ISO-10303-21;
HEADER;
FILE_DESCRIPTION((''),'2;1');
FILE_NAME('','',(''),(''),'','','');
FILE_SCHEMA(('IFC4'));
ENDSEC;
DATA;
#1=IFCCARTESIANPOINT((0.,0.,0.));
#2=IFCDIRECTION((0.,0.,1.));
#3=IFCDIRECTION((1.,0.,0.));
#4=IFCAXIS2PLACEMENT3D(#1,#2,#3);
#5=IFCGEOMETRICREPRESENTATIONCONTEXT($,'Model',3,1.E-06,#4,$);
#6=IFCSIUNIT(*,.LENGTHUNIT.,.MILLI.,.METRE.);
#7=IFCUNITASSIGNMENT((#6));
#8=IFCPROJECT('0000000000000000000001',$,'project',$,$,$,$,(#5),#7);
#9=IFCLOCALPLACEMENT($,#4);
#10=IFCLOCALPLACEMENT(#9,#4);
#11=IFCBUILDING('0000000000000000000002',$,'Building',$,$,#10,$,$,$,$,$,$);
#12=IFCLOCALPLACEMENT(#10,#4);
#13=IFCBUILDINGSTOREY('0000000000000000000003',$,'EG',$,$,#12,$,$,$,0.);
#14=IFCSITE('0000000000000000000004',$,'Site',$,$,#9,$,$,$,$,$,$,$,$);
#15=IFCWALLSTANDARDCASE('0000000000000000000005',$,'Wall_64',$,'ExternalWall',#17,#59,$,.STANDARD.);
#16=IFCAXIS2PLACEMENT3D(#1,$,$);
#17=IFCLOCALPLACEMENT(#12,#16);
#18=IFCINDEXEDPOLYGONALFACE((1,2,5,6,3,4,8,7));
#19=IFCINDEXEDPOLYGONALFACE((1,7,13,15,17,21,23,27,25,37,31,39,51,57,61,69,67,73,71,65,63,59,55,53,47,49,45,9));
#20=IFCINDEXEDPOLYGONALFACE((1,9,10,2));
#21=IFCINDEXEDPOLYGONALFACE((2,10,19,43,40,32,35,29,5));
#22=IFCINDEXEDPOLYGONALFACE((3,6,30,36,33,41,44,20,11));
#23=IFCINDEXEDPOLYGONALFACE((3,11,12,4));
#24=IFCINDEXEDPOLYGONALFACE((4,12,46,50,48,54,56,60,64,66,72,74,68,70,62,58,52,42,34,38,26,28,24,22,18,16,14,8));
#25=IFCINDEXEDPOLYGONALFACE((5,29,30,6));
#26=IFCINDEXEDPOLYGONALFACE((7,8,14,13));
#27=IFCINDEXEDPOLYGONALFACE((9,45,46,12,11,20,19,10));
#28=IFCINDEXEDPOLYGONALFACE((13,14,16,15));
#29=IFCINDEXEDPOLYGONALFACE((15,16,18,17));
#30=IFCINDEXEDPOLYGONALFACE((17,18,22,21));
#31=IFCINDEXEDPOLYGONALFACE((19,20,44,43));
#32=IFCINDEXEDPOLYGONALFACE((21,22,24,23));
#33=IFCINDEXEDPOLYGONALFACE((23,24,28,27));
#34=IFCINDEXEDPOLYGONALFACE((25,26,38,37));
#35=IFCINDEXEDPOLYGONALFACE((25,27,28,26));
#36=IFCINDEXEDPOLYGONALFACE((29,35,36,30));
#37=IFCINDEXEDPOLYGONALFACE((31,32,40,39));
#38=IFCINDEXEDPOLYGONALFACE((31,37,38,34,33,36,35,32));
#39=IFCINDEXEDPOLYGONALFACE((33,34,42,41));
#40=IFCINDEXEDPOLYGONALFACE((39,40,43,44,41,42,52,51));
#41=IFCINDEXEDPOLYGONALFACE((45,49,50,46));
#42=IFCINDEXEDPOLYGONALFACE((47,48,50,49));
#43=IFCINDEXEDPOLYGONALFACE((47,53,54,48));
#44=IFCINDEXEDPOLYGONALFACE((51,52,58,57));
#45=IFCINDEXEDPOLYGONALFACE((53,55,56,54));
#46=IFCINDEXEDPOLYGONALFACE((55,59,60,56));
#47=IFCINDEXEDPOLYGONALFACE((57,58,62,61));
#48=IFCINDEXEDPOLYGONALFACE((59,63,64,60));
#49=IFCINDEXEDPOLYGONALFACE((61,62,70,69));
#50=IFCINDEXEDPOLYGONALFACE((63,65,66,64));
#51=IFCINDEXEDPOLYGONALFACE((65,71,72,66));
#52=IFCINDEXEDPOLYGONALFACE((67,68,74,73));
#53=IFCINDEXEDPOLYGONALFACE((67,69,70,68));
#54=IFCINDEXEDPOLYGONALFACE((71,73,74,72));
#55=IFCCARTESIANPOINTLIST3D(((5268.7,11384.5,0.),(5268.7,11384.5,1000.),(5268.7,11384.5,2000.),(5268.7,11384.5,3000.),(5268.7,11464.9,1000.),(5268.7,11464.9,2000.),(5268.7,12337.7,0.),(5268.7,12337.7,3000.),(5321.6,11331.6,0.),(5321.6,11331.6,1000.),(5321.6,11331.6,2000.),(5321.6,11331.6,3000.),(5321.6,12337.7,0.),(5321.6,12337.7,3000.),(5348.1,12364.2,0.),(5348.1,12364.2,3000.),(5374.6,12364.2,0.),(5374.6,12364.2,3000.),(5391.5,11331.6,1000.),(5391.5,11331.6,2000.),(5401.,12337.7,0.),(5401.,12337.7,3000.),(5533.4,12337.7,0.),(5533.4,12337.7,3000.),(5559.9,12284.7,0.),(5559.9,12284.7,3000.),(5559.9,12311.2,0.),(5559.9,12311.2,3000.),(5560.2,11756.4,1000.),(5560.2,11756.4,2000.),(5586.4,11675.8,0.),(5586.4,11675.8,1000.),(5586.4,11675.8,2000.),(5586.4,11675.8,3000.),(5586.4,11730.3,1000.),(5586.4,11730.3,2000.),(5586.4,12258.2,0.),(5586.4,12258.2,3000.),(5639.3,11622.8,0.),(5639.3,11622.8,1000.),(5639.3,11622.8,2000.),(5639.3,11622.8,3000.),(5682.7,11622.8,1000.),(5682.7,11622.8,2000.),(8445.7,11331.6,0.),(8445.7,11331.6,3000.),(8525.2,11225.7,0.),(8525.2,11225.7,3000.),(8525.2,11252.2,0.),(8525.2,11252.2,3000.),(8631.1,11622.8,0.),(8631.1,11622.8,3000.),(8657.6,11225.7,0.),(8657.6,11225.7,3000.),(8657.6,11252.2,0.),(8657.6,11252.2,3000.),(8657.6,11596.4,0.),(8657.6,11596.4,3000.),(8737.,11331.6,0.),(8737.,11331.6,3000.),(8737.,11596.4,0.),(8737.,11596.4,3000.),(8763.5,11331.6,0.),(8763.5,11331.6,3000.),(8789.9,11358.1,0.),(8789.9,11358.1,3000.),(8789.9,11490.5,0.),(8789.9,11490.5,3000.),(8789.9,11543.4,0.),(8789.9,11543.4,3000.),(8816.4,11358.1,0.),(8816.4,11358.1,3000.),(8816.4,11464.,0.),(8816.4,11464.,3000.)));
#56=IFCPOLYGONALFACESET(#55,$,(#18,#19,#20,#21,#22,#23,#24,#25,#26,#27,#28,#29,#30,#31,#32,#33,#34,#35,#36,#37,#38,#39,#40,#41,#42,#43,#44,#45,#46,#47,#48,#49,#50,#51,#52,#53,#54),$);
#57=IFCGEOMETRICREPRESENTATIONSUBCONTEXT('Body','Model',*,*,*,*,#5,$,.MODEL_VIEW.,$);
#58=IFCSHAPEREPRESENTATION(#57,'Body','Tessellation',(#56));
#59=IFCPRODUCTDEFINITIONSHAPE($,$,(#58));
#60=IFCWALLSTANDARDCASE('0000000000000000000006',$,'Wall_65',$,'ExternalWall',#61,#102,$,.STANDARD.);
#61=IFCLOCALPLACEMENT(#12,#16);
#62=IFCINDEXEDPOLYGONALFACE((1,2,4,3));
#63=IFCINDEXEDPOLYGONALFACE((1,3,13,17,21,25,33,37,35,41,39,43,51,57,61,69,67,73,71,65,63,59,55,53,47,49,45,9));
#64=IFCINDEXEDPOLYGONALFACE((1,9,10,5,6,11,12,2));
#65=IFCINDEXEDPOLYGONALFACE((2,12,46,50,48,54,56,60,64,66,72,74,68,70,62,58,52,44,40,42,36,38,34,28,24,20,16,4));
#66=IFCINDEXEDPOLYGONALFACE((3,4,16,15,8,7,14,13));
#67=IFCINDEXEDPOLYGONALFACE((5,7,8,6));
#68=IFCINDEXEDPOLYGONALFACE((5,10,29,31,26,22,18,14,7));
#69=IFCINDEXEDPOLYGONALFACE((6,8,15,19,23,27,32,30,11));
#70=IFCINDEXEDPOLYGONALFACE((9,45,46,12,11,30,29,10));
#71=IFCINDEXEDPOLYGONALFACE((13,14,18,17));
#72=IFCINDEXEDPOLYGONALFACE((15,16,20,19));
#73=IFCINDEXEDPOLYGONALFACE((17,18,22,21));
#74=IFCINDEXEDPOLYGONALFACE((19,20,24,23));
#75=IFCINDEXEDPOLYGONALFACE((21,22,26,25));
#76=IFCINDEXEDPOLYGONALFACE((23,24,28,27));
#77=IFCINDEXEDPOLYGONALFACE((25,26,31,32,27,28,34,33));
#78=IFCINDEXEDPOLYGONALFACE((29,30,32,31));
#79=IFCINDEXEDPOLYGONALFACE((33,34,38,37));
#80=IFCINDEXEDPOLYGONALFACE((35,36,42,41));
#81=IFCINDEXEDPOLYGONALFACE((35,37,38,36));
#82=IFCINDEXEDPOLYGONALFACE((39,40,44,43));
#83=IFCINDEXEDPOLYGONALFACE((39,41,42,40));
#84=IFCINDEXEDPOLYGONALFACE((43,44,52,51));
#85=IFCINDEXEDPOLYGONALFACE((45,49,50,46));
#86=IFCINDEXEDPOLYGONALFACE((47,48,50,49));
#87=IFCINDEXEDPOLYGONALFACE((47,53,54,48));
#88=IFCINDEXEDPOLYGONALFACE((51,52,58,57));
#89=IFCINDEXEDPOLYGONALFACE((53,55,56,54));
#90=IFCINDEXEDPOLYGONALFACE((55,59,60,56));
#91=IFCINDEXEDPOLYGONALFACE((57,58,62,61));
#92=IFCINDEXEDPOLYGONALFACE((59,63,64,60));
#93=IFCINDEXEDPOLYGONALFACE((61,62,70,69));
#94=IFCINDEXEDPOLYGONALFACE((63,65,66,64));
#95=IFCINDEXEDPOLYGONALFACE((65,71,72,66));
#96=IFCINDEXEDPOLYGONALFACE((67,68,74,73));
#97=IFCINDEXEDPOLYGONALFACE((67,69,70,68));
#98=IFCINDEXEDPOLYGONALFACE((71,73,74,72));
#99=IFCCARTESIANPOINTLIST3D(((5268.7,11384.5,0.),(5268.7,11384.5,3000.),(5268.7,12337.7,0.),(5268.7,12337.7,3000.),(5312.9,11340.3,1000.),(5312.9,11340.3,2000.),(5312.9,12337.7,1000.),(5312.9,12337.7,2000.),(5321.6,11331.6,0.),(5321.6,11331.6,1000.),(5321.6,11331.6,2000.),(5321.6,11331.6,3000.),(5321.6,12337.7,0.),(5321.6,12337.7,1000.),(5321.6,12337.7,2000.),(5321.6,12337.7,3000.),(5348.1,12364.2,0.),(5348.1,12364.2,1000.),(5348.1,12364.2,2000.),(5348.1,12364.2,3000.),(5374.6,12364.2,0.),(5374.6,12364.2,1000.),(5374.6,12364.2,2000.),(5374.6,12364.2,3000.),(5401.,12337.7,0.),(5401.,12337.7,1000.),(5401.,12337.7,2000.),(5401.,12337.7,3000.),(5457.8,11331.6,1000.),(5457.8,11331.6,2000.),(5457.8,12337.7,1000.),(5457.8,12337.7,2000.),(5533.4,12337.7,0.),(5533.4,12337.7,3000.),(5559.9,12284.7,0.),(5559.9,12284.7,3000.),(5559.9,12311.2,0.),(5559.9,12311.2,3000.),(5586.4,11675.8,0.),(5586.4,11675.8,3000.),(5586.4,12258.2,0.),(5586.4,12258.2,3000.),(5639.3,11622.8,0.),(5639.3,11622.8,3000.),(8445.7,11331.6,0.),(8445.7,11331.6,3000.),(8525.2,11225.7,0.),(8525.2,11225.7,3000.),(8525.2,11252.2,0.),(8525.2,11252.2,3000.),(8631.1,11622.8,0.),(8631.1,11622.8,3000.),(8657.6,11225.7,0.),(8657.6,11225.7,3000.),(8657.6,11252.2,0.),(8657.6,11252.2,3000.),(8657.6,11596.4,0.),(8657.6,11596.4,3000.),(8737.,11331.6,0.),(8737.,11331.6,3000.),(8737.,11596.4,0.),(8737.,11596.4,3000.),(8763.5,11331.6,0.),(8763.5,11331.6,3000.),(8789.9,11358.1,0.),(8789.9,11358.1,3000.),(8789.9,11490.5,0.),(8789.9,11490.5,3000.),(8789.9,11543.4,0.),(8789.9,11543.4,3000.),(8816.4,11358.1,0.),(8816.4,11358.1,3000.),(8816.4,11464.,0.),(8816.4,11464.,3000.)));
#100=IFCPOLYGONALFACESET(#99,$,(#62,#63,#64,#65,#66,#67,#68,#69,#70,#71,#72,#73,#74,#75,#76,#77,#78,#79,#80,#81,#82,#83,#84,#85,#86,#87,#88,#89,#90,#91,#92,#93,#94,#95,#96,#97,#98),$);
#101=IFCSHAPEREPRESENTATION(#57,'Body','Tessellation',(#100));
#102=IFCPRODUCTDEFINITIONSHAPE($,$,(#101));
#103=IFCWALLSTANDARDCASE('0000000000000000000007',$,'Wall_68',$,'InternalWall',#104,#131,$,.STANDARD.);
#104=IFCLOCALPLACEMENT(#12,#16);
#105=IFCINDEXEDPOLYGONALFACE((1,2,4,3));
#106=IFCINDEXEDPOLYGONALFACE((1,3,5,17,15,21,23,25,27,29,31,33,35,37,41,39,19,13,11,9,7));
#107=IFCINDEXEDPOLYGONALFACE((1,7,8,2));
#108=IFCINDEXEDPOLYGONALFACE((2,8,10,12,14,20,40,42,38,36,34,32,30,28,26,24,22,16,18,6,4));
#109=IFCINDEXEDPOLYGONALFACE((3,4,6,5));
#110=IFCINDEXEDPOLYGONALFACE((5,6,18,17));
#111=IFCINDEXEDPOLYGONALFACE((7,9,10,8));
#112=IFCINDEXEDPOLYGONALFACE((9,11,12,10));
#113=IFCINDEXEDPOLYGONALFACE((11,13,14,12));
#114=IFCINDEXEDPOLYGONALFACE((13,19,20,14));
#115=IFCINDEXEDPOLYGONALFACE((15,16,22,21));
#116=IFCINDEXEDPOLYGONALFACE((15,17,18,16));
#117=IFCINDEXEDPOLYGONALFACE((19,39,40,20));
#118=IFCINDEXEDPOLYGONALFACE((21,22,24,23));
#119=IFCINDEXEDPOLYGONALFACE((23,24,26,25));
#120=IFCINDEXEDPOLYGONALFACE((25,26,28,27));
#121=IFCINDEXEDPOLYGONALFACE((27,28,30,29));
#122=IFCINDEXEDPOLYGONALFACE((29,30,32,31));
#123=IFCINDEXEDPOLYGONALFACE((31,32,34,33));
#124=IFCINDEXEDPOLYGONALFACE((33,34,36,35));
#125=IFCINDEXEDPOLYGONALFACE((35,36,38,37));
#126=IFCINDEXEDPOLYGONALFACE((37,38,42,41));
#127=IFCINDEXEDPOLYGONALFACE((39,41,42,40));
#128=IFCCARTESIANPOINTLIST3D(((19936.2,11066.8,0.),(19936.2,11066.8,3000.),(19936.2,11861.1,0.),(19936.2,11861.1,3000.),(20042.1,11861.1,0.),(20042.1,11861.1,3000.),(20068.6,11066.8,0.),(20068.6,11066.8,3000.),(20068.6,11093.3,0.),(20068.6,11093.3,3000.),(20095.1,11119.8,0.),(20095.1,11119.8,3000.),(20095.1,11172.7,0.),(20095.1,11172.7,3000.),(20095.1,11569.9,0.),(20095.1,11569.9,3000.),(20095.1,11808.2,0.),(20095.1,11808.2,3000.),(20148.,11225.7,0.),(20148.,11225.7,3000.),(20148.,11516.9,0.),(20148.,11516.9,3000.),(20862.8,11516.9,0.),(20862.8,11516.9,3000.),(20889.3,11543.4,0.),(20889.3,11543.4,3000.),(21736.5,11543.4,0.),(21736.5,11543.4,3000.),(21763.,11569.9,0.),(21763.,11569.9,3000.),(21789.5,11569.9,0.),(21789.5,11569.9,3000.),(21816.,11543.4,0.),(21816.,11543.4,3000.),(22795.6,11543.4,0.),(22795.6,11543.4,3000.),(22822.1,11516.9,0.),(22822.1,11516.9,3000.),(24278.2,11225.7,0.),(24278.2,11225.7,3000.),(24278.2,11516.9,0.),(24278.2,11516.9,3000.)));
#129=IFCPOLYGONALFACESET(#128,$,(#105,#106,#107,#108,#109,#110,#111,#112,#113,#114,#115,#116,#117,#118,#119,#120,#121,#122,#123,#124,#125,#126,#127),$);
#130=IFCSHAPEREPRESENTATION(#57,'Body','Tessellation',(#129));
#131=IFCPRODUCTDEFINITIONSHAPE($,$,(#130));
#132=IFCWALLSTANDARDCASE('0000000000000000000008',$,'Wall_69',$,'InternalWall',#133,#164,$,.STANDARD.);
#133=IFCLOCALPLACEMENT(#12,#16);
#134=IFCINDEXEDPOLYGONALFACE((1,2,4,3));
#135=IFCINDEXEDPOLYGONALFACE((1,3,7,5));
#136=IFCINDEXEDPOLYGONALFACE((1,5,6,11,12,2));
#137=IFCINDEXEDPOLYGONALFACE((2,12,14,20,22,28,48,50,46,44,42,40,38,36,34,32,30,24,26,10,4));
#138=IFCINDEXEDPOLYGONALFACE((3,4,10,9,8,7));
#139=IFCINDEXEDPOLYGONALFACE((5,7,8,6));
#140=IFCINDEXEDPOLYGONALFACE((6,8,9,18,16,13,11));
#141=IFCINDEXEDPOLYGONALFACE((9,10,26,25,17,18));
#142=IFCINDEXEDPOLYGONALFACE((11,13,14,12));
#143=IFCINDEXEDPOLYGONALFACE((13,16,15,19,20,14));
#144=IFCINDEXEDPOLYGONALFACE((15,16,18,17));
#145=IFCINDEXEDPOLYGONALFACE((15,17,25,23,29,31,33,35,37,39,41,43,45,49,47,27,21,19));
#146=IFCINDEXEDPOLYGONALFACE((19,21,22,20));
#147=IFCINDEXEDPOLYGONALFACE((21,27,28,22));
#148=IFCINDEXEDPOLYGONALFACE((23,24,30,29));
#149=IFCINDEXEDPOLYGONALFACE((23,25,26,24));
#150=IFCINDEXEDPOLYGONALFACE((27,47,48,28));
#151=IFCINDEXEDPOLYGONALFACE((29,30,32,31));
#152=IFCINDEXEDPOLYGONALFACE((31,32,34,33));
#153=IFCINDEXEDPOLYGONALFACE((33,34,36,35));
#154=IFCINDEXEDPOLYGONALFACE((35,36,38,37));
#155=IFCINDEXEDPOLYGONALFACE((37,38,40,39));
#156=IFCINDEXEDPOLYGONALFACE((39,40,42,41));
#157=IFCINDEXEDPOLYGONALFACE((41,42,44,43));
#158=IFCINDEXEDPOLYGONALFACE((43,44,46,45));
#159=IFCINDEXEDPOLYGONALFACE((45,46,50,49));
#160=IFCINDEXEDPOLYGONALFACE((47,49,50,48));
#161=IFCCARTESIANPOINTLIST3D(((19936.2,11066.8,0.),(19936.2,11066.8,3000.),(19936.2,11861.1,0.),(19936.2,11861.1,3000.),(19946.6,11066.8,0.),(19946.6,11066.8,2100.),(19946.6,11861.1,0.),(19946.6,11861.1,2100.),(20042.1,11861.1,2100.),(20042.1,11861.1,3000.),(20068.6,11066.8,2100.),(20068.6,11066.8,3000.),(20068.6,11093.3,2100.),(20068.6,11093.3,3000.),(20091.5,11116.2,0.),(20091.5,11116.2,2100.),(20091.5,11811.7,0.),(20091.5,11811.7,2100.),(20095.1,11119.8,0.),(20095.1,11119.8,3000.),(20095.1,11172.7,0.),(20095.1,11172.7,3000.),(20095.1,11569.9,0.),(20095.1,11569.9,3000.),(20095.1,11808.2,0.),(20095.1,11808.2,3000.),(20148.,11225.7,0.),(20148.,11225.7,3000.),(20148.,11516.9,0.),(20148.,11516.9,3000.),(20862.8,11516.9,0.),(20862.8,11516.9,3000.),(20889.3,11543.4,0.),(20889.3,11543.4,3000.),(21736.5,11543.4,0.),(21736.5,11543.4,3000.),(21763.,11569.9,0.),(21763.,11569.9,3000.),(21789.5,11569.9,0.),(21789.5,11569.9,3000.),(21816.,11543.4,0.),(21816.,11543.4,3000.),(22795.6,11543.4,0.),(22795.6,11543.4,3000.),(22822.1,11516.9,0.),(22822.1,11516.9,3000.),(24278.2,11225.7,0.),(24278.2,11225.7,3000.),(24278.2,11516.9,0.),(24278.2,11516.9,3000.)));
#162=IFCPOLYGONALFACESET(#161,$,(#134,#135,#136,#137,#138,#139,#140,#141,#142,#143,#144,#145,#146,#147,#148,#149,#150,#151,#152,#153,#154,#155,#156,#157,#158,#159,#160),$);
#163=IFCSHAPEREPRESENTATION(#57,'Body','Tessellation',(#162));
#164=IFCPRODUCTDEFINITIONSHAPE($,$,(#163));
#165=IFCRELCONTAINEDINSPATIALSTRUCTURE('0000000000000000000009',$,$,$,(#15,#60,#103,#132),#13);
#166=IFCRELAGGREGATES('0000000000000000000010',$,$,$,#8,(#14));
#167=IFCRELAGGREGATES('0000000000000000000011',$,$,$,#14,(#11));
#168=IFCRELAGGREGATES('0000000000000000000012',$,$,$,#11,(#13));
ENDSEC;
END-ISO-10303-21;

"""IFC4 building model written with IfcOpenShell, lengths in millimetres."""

from ifc_helpers import new_model, si_unit, frame, origin_with_axes, place, context, subcontext, project, spatial, polyline, rectangle, outline, extrude, element, save


model = new_model("IFC4")

# Units and contexts
model_context = context("Model", 3, precision=1e-06, world=origin_with_axes())
body_context = subcontext(model_context, "Body", "Model", "MODEL_VIEW")
ifc_project = project(units=[si_unit("LENGTHUNIT", "METRE", prefix="MILLI")], contexts=[model_context])

# Site, building, storey
site_placement = place(None, origin_with_axes())
site = spatial("IfcSite", under=ifc_project, at=site_placement, Name="Site")
building_placement = place(site_placement, origin_with_axes())
building = spatial("IfcBuilding", under=site, at=building_placement, Name="Building")
storey_placement = place(building_placement, origin_with_axes())
storey = spatial("IfcBuildingStorey", under=building, at=storey_placement, Name="EG", Elevation=0.0)

# Walls, openings
wall_1_placement = place(storey_placement, origin_with_axes())
wall_1 = element("IfcWallStandardCase", 1, at=wall_1_placement, inside=storey, Name="Wall_64", ObjectType="ExternalWall", PredefinedType="STANDARD", context=body_context, shape_type="SweptSolid", body=[
    extrude(outline(polyline([(8525.2, 11225.7, 0.0), (8525.2, 11252.2, 0.0), (8445.7, 11331.6, 0.0), (5321.6, 11331.6, 0.0), (5268.7, 11384.5, 0.0), (5268.7, 12337.7, 0.0), (5321.6, 12337.7, 0.0), (5348.1, 12364.2, 0.0), (5374.6, 12364.2, 0.0), (5401.0, 12337.7, 0.0), (5533.4, 12337.7, 0.0), (5559.9, 12311.2, 0.0), (5559.9, 12284.7, 0.0), (5586.4, 12258.2, 0.0), (5586.4, 11675.8, 0.0), (5639.3, 11622.8, 0.0), (8631.1, 11622.8, 0.0), (8657.6, 11596.4, 0.0), (8737.0, 11596.4, 0.0), (8789.9, 11543.4, 0.0), (8789.9, 11490.5, 0.0), (8816.4, 11464.0, 0.0), (8816.4, 11358.1, 0.0), (8789.9, 11358.1, 0.0), (8763.5, 11331.6, 0.0), (8737.0, 11331.6, 0.0), (8657.6, 11252.2, 0.0), (8657.6, 11225.7, 0.0), (8525.2, 11225.7, 0.0)])), origin_with_axes(), (0.0, 0.0, 1.0), 3000.0),
])
opening_1_placement = place(wall_1_placement, origin_with_axes())
element("IfcOpeningElement", 2, at=opening_1_placement, inside=storey, cuts=wall_1, context=body_context, shape_type="SweptSolid", body=[
    extrude(rectangle(XDim=636.5, YDim=181.1), frame((5399.2, 11467.4, 1000.0), z_axis=(0.0, 0.0, 1.0), x_axis=(-0.707107, -0.707107, 0.0)), (0.0, 0.0, 1.0), 1000.0),
])
wall_2_placement = place(storey_placement, origin_with_axes())
wall_2 = element("IfcWallStandardCase", 3, at=wall_2_placement, inside=storey, Name="Wall_65", ObjectType="ExternalWall", PredefinedType="STANDARD", context=body_context, shape_type="SweptSolid", body=[
    extrude(outline(polyline([(8525.2, 11225.7, 0.0), (8525.2, 11252.2, 0.0), (8445.7, 11331.6, 0.0), (5321.6, 11331.6, 0.0), (5268.7, 11384.5, 0.0), (5268.7, 12337.7, 0.0), (5321.6, 12337.7, 0.0), (5348.1, 12364.2, 0.0), (5374.6, 12364.2, 0.0), (5401.0, 12337.7, 0.0), (5533.4, 12337.7, 0.0), (5559.9, 12311.2, 0.0), (5559.9, 12284.7, 0.0), (5586.4, 12258.2, 0.0), (5586.4, 11675.8, 0.0), (5639.3, 11622.8, 0.0), (8631.1, 11622.8, 0.0), (8657.6, 11596.4, 0.0), (8737.0, 11596.4, 0.0), (8789.9, 11543.4, 0.0), (8789.9, 11490.5, 0.0), (8816.4, 11464.0, 0.0), (8816.4, 11358.1, 0.0), (8789.9, 11358.1, 0.0), (8763.5, 11331.6, 0.0), (8737.0, 11331.6, 0.0), (8657.6, 11252.2, 0.0), (8657.6, 11225.7, 0.0), (8525.2, 11225.7, 0.0)])), origin_with_axes(), (0.0, 0.0, 1.0), 3000.0),
])
opening_2_placement = place(wall_2_placement, origin_with_axes())
element("IfcOpeningElement", 4, at=opening_2_placement, inside=storey, cuts=wall_2, context=body_context, shape_type="SweptSolid", body=[
    extrude(rectangle(XDim=2592.1, YDim=144.9), frame((5385.3, 12245.1, 1000.0), z_axis=(0.0, 0.0, 1.0), x_axis=(0.0, 1.0, 0.0)), (0.0, 0.0, 1.0), 1000.0),
])

# Wall
wall_3_placement = place(storey_placement, origin_with_axes())
element("IfcWallStandardCase", 5, at=wall_3_placement, inside=storey, Name="Wall_68", ObjectType="InternalWall", PredefinedType="STANDARD", context=body_context, shape_type="SweptSolid", body=[
    extrude(outline(polyline([(19936.2, 11066.8, 0.0), (19936.2, 11861.1, 0.0), (20042.1, 11861.1, 0.0), (20095.1, 11808.2, 0.0), (20095.1, 11569.9, 0.0), (20148.0, 11516.9, 0.0), (20862.8, 11516.9, 0.0), (20889.3, 11543.4, 0.0), (21736.5, 11543.4, 0.0), (21763.0, 11569.9, 0.0), (21789.5, 11569.9, 0.0), (21816.0, 11543.4, 0.0), (22795.6, 11543.4, 0.0), (22822.1, 11516.9, 0.0), (24278.2, 11516.9, 0.0), (24278.2, 11225.7, 0.0), (20148.0, 11225.7, 0.0), (20095.1, 11172.7, 0.0), (20095.1, 11119.8, 0.0), (20068.6, 11093.3, 0.0), (20068.6, 11066.8, 0.0), (19936.2, 11066.8, 0.0)])), origin_with_axes(), (0.0, 0.0, 1.0), 3000.0),
])

# Wall, openings
wall_4_placement = place(storey_placement, origin_with_axes())
wall_4 = element("IfcWallStandardCase", 6, at=wall_4_placement, inside=storey, Name="Wall_69", ObjectType="InternalWall", PredefinedType="STANDARD", context=body_context, shape_type="SweptSolid", body=[
    extrude(outline(polyline([(19936.2, 11066.8, 0.0), (19936.2, 11861.1, 0.0), (20042.1, 11861.1, 0.0), (20095.1, 11808.2, 0.0), (20095.1, 11569.9, 0.0), (20148.0, 11516.9, 0.0), (20862.8, 11516.9, 0.0), (20889.3, 11543.4, 0.0), (21736.5, 11543.4, 0.0), (21763.0, 11569.9, 0.0), (21789.5, 11569.9, 0.0), (21816.0, 11543.4, 0.0), (22795.6, 11543.4, 0.0), (22822.1, 11516.9, 0.0), (24278.2, 11516.9, 0.0), (24278.2, 11225.7, 0.0), (20148.0, 11225.7, 0.0), (20095.1, 11172.7, 0.0), (20095.1, 11119.8, 0.0), (20068.6, 11093.3, 0.0), (20068.6, 11066.8, 0.0), (19936.2, 11066.8, 0.0)])), origin_with_axes(), (0.0, 0.0, 1.0), 3000.0),
])
opening_3_placement = place(wall_4_placement, origin_with_axes())
element("IfcOpeningElement", 7, at=opening_3_placement, inside=storey, cuts=wall_4, context=body_context, shape_type="SweptSolid", body=[
    extrude(rectangle(XDim=1059.0, YDim=144.9), frame((20019.0, 11461.3, 0.0), z_axis=(0.0, 0.0, 1.0), x_axis=(0.0, -1.0, 0.0)), (0.0, 0.0, 1.0), 2100.0),
])
opening_4_placement = place(wall_4_placement, origin_with_axes())
element("IfcOpeningElement", 8, at=opening_4_placement, inside=storey, cuts=wall_4, context=body_context, shape_type="SweptSolid", body=[
    extrude(rectangle(XDim=847.2, YDim=144.9), frame((20019.0, 11461.3, 0.0), z_axis=(0.0, 0.0, 1.0), x_axis=(0.0, -1.0, 0.0)), (0.0, 0.0, 1.0), 2100.0),
])

save(model, "model.ifc")
